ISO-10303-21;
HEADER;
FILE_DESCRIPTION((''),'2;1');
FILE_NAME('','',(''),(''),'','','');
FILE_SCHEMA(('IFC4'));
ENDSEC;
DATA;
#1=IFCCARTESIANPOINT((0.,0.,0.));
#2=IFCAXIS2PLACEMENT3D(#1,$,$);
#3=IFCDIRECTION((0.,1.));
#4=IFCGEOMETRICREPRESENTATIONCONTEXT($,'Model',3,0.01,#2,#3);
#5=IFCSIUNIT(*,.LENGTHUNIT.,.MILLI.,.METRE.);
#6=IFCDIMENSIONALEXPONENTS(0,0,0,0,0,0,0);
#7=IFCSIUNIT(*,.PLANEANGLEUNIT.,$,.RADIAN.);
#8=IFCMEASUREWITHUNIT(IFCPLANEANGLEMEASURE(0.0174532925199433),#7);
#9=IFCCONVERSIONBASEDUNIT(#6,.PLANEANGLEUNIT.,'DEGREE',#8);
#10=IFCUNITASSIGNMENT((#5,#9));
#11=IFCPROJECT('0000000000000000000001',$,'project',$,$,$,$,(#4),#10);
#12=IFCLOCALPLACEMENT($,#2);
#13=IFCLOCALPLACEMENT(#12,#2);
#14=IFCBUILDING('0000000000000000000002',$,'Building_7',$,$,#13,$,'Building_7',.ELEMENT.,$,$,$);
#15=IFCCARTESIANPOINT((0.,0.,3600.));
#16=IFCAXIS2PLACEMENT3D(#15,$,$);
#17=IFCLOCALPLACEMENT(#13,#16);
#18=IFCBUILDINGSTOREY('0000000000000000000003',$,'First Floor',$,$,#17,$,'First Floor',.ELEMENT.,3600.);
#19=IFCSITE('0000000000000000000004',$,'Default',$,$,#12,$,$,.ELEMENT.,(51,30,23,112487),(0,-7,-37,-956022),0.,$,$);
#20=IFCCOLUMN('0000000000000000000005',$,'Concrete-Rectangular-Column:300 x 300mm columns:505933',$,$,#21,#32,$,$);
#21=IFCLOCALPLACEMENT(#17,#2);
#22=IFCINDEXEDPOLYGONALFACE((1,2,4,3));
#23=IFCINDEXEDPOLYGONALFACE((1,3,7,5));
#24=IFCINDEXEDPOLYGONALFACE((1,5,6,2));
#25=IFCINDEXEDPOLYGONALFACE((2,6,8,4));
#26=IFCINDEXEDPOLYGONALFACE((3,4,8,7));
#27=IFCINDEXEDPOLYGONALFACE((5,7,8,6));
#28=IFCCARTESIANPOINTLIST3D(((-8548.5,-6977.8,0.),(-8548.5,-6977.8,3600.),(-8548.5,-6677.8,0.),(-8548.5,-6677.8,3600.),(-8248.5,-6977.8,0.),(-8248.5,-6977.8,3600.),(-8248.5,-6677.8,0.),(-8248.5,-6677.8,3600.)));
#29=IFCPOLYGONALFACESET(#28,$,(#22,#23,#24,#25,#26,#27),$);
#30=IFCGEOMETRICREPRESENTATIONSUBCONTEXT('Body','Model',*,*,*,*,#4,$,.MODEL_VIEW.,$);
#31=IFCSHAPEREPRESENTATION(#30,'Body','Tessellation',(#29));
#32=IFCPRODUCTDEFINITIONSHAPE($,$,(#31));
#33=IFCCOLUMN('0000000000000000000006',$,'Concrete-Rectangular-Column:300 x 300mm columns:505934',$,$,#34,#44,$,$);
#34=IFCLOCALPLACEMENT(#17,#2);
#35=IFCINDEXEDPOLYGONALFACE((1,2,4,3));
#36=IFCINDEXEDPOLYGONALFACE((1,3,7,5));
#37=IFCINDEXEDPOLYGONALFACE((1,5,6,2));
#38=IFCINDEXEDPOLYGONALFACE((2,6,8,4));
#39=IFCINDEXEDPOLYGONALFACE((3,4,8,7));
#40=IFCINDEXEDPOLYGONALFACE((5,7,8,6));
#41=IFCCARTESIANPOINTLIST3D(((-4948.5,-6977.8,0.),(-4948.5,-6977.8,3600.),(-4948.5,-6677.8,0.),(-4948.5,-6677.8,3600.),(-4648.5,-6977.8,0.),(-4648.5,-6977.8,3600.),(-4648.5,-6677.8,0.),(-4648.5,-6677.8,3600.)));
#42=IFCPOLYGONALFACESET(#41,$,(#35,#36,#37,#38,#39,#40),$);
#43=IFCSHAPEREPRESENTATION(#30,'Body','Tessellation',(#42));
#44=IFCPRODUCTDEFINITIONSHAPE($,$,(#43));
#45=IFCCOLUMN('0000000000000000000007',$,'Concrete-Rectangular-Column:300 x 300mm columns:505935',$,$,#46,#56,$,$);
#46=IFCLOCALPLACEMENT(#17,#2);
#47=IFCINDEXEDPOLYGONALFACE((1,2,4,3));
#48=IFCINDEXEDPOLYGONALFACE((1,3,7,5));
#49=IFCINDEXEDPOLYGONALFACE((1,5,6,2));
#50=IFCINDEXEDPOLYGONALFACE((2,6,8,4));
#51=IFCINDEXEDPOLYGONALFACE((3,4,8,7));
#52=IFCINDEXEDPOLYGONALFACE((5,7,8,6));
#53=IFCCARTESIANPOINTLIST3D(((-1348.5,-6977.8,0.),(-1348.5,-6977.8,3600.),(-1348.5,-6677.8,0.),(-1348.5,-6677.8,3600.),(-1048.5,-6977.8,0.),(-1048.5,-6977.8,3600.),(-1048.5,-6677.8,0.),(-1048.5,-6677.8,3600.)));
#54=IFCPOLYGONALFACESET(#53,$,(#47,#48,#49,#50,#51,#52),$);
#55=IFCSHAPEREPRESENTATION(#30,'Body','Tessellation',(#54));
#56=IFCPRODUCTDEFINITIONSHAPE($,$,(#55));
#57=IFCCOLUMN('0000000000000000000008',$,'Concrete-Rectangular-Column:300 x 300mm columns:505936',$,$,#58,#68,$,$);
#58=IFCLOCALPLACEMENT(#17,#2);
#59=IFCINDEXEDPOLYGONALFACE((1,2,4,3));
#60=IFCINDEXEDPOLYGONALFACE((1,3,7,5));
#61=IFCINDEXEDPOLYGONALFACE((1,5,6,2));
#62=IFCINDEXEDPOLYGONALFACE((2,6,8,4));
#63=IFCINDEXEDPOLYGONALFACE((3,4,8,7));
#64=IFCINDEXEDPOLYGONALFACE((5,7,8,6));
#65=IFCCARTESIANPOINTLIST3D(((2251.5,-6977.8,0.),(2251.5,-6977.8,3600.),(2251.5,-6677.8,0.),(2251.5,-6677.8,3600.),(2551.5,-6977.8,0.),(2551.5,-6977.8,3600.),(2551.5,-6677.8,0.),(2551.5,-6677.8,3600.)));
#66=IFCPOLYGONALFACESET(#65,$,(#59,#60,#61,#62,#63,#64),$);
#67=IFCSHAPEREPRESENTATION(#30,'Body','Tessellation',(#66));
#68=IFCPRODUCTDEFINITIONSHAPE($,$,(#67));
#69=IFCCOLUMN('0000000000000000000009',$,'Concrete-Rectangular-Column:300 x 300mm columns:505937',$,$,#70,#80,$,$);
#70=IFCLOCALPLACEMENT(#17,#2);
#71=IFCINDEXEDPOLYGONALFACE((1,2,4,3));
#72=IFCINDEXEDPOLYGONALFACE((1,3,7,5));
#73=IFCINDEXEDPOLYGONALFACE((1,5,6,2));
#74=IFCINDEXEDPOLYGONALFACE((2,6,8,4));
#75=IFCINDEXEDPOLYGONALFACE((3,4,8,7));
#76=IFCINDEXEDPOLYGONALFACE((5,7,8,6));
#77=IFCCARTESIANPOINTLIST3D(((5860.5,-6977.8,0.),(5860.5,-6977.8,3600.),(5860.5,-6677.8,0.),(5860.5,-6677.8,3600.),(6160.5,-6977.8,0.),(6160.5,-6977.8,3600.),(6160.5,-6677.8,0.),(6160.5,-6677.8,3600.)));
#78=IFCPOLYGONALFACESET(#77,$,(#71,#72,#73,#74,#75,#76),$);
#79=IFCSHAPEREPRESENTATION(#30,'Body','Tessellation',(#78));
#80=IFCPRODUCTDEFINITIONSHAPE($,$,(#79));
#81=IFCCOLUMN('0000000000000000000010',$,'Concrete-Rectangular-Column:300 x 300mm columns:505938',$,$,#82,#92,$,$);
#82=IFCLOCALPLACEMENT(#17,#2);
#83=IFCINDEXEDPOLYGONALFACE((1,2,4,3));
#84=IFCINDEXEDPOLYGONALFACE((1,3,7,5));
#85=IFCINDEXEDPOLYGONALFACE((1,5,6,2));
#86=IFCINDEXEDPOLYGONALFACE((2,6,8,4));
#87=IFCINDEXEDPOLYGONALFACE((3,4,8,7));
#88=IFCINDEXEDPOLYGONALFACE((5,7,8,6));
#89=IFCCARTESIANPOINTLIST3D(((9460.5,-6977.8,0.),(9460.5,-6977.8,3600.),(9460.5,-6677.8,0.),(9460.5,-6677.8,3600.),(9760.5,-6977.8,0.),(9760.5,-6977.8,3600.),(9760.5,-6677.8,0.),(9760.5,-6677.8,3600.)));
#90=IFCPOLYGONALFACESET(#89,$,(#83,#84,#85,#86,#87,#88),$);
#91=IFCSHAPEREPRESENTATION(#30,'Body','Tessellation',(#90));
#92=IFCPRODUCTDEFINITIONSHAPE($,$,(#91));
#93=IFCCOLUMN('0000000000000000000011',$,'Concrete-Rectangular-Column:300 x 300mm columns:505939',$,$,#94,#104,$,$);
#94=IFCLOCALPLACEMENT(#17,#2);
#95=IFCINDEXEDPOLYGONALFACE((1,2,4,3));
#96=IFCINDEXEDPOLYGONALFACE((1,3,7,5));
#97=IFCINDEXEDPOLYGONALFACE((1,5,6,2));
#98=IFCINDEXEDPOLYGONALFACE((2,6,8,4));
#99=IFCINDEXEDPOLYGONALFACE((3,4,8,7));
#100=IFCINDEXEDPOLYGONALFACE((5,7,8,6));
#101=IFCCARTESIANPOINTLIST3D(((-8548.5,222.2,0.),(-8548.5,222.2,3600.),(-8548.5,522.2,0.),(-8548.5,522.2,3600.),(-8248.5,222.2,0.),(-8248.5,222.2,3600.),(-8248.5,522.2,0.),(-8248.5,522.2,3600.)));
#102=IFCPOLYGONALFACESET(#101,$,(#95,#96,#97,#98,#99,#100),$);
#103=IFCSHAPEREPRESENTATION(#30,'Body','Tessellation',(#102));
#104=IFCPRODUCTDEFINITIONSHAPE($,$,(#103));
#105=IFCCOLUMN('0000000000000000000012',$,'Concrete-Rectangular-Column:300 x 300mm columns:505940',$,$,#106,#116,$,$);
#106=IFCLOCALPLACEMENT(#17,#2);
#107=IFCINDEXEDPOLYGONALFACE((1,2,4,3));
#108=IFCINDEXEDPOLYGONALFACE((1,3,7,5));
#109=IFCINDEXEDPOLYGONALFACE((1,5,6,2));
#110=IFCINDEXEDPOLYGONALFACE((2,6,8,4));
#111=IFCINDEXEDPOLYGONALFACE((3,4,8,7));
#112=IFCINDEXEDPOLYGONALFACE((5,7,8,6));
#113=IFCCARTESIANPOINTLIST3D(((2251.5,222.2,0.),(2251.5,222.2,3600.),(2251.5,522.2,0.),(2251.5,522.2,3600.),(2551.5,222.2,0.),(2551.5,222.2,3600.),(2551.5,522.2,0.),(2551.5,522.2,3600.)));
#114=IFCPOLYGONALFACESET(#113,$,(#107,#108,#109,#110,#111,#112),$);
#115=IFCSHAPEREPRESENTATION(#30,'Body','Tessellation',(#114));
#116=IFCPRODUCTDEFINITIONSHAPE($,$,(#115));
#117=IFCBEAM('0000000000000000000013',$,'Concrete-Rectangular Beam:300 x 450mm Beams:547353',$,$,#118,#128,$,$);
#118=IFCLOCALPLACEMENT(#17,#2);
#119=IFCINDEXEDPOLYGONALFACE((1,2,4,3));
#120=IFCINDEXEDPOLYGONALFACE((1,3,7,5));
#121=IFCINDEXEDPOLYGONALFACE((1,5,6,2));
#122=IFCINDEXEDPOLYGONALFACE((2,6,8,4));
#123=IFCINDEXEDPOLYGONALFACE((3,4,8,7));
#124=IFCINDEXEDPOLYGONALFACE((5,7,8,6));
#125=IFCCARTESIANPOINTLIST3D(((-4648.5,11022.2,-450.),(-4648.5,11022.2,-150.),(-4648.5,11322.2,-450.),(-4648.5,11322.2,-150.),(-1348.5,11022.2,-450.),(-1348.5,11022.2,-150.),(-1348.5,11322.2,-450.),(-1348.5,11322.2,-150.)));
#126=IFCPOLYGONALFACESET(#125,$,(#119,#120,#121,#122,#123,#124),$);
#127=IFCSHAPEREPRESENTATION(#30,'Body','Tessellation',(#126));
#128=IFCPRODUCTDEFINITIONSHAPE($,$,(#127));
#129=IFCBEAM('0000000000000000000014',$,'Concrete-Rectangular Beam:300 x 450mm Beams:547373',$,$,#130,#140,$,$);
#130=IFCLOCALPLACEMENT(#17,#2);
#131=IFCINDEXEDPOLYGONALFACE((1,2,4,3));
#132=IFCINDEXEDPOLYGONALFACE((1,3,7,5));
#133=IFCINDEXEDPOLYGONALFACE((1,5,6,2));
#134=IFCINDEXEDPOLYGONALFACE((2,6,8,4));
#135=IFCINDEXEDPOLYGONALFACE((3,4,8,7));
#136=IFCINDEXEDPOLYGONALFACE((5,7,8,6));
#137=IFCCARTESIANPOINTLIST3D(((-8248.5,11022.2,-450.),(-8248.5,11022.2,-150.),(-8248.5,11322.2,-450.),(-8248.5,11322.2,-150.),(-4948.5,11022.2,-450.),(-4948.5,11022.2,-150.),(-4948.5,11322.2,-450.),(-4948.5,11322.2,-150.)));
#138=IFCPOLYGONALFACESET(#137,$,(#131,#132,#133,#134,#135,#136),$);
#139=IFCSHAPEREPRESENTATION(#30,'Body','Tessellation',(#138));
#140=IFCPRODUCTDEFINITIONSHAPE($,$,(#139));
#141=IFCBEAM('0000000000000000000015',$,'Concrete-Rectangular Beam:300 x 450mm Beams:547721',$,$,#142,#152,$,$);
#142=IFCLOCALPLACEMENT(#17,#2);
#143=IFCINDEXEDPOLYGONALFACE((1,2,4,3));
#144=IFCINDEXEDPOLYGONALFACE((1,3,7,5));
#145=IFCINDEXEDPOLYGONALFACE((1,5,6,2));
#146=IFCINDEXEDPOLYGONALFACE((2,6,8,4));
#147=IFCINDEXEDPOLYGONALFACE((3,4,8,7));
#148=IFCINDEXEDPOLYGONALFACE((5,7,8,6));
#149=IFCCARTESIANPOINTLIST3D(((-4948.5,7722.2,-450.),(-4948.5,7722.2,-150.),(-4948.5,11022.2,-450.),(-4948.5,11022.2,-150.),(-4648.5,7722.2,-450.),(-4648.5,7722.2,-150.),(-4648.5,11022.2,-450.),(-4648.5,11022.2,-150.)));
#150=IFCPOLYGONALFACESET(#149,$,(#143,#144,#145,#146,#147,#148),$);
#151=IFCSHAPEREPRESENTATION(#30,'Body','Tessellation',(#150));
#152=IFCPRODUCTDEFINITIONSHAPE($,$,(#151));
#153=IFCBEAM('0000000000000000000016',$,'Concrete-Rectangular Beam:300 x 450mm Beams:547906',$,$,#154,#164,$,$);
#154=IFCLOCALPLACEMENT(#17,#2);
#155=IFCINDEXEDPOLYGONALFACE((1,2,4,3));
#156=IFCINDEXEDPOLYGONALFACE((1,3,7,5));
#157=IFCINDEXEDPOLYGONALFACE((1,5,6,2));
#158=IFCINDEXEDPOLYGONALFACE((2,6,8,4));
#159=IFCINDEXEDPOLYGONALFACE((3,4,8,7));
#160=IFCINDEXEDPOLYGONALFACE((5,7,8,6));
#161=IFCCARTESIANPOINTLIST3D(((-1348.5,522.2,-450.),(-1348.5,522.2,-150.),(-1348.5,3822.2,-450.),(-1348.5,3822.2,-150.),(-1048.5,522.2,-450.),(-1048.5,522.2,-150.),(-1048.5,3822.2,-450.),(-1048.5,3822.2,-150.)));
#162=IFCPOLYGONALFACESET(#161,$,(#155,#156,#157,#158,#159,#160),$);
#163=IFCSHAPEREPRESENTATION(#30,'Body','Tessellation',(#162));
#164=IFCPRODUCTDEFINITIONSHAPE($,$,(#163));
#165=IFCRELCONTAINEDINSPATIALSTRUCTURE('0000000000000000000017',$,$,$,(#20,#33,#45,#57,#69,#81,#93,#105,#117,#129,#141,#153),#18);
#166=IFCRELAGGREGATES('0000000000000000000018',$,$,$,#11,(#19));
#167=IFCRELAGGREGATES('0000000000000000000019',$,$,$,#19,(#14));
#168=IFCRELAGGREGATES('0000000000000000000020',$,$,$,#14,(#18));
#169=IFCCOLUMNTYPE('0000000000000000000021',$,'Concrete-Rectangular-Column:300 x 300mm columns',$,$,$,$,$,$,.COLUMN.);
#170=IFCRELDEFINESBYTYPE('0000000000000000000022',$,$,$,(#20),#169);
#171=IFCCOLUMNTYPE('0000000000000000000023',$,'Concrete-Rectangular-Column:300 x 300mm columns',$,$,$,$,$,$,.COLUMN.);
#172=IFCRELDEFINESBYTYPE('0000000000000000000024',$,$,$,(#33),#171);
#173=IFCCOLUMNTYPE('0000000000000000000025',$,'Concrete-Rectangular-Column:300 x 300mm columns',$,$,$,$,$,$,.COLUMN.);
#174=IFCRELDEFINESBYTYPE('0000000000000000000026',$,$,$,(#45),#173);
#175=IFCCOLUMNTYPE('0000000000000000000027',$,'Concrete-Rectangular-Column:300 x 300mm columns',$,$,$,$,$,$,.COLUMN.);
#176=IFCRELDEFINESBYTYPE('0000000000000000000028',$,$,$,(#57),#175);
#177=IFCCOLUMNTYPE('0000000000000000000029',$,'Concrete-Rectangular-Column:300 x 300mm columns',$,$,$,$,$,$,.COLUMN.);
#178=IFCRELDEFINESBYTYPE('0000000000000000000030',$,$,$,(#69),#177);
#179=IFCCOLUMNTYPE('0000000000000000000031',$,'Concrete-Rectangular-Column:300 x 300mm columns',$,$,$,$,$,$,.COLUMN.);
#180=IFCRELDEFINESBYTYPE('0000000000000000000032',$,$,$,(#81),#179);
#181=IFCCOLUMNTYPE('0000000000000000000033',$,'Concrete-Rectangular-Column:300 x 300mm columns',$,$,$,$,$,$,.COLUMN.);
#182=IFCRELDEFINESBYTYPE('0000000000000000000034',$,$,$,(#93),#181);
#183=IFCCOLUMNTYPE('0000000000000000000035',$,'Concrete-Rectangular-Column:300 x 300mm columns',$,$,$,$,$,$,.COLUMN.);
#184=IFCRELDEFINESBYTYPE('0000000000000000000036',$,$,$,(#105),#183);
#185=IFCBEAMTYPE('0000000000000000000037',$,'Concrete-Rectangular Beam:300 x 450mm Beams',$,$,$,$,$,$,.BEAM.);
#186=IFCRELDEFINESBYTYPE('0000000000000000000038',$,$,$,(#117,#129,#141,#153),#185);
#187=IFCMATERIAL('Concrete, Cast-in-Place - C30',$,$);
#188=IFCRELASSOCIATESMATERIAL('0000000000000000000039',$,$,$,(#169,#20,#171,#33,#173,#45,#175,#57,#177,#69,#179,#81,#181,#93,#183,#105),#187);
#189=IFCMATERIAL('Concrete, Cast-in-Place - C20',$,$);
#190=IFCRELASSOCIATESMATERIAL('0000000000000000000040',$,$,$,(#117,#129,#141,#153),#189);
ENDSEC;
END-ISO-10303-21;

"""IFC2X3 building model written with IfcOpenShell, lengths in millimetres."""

from ifc_helpers import new_model, entity, si_unit, converted_unit, direction, frame, frame_2d, origin, place, context, subcontext, project, spatial, rectangle, extrude, source, transform, mapped, material, type_object, type_shapes, element, save


model = new_model("IFC2X3")

# Units and contexts
model_context = context("Model", 3, precision=0.01, world=origin(), true_north=direction((0.0, 1.0)))
body_context = subcontext(model_context, "Body", "Model", "MODEL_VIEW")
ifc_project = project(units=[si_unit("LENGTHUNIT", "METRE", prefix="MILLI"), converted_unit("PLANEANGLEUNIT", "DEGREE", entity("IfcPlaneAngleMeasure", 0.0174532925199433), si_unit("PLANEANGLEUNIT", "RADIAN"), dimensions=[0, 0, 0, 0, 0, 0, 0])], contexts=[model_context])

# Site, building, storey
site_placement = place(None, origin())
site = spatial("IfcSite", under=ifc_project, at=site_placement, Name="Default", CompositionType="ELEMENT", RefLatitude=(51, 30, 23, 112487), RefLongitude=(0, -7, -37, -956022), RefElevation=0.0)
building_placement = place(site_placement, origin())
building = spatial("IfcBuilding", under=site, at=building_placement, Name="Building_7", LongName="Building_7", CompositionType="ELEMENT")
storey_placement = place(building_placement, frame((0.0, 0.0, 3600.0)))
storey = spatial("IfcBuildingStorey", under=building, at=storey_placement, Name="First Floor", LongName="First Floor", CompositionType="ELEMENT", Elevation=3600.0)

# Columns
ifc_material_1 = material(Name="Concrete, Cast-in-Place - C30")
column_type_1 = type_object("IfcColumnType", Name="Concrete-Rectangular-Column:300 x 300mm columns", PredefinedType="COLUMN", material=ifc_material_1)
shared_shape_1 = source(origin(), body_context, "Body", "SweptSolid", [
    extrude(rectangle(XDim=300.0, YDim=300.0, at=frame_2d((0.0, 0.0), x_axis=(1.0, 0.0))), frame((-8398.5, -6827.8, 3600.0), z_axis=(0.0, 0.0, 1.0), x_axis=(-1.0, 0.0, 0.0)), (0.0, 0.0, 1.0), 3600.0),
])
type_shapes(column_type_1, [shared_shape_1])
column_1_placement = place(storey_placement, frame((0.0, 0.0, -3600.0)))
element("IfcColumn", 1, at=column_1_placement, inside=storey, type_object=column_type_1, material=ifc_material_1, Name="Concrete-Rectangular-Column:300 x 300mm columns:505933", context=body_context, shape_type="MappedRepresentation", body=[
    mapped(shared_shape_1, transform((0.0, 0.0, 0.0), scale=1.0)),
])
column_type_2 = type_object("IfcColumnType", Name="Concrete-Rectangular-Column:300 x 300mm columns", PredefinedType="COLUMN", material=ifc_material_1)
shared_shape_2 = source(origin(), body_context, "Body", "SweptSolid", [
    extrude(rectangle(XDim=300.0, YDim=300.0, at=frame_2d((0.0, 0.0), x_axis=(1.0, 0.0))), frame((-4798.5, -6827.8, 3600.0), z_axis=(0.0, 0.0, 1.0), x_axis=(-1.0, 0.0, 0.0)), (0.0, 0.0, 1.0), 3600.0),
])
type_shapes(column_type_2, [shared_shape_2])
column_2_placement = place(storey_placement, frame((0.0, 0.0, -3600.0)))
element("IfcColumn", 2, at=column_2_placement, inside=storey, type_object=column_type_2, material=ifc_material_1, Name="Concrete-Rectangular-Column:300 x 300mm columns:505934", context=body_context, shape_type="MappedRepresentation", body=[
    mapped(shared_shape_2, transform((0.0, 0.0, 0.0), scale=1.0)),
])
column_type_3 = type_object("IfcColumnType", Name="Concrete-Rectangular-Column:300 x 300mm columns", PredefinedType="COLUMN", material=ifc_material_1)
shared_shape_3 = source(origin(), body_context, "Body", "SweptSolid", [
    extrude(rectangle(XDim=300.0, YDim=300.0, at=frame_2d((0.0, 0.0), x_axis=(1.0, 0.0))), frame((-1198.5, -6827.8, 3600.0), z_axis=(0.0, 0.0, 1.0), x_axis=(-1.0, 0.0, 0.0)), (0.0, 0.0, 1.0), 3600.0),
])
type_shapes(column_type_3, [shared_shape_3])
column_3_placement = place(storey_placement, frame((0.0, 0.0, -3600.0)))
element("IfcColumn", 3, at=column_3_placement, inside=storey, type_object=column_type_3, material=ifc_material_1, Name="Concrete-Rectangular-Column:300 x 300mm columns:505935", context=body_context, shape_type="MappedRepresentation", body=[
    mapped(shared_shape_3, transform((0.0, 0.0, 0.0), scale=1.0)),
])
column_type_4 = type_object("IfcColumnType", Name="Concrete-Rectangular-Column:300 x 300mm columns", PredefinedType="COLUMN", material=ifc_material_1)
shared_shape_4 = source(origin(), body_context, "Body", "SweptSolid", [
    extrude(rectangle(XDim=300.0, YDim=300.0, at=frame_2d((0.0, 0.0), x_axis=(1.0, 0.0))), frame((2401.5, -6827.8, 3600.0), z_axis=(0.0, 0.0, 1.0), x_axis=(-1.0, 0.0, 0.0)), (0.0, 0.0, 1.0), 3600.0),
])
type_shapes(column_type_4, [shared_shape_4])
column_4_placement = place(storey_placement, frame((0.0, 0.0, -3600.0)))
element("IfcColumn", 4, at=column_4_placement, inside=storey, type_object=column_type_4, material=ifc_material_1, Name="Concrete-Rectangular-Column:300 x 300mm columns:505936", context=body_context, shape_type="MappedRepresentation", body=[
    mapped(shared_shape_4, transform((0.0, 0.0, 0.0), scale=1.0)),
])
column_type_5 = type_object("IfcColumnType", Name="Concrete-Rectangular-Column:300 x 300mm columns", PredefinedType="COLUMN", material=ifc_material_1)
shared_shape_5 = source(origin(), body_context, "Body", "SweptSolid", [
    extrude(rectangle(XDim=300.0, YDim=300.0, at=frame_2d((0.0, 0.0), x_axis=(1.0, 0.0))), frame((6010.5, -6827.8, 3600.0), z_axis=(0.0, 0.0, 1.0), x_axis=(-1.0, 0.0, 0.0)), (0.0, 0.0, 1.0), 3600.0),
])
type_shapes(column_type_5, [shared_shape_5])
column_5_placement = place(storey_placement, frame((0.0, 0.0, -3600.0)))
element("IfcColumn", 5, at=column_5_placement, inside=storey, type_object=column_type_5, material=ifc_material_1, Name="Concrete-Rectangular-Column:300 x 300mm columns:505937", context=body_context, shape_type="MappedRepresentation", body=[
    mapped(shared_shape_5, transform((0.0, 0.0, 0.0), scale=1.0)),
])
column_type_6 = type_object("IfcColumnType", Name="Concrete-Rectangular-Column:300 x 300mm columns", PredefinedType="COLUMN", material=ifc_material_1)
shared_shape_6 = source(origin(), body_context, "Body", "SweptSolid", [
    extrude(rectangle(XDim=300.0, YDim=300.0, at=frame_2d((0.0, 0.0), x_axis=(1.0, 0.0))), frame((9610.5, -6827.8, 3600.0), z_axis=(0.0, 0.0, 1.0), x_axis=(-1.0, 0.0, 0.0)), (0.0, 0.0, 1.0), 3600.0),
])
type_shapes(column_type_6, [shared_shape_6])
column_6_placement = place(storey_placement, frame((0.0, 0.0, -3600.0)))
element("IfcColumn", 6, at=column_6_placement, inside=storey, type_object=column_type_6, material=ifc_material_1, Name="Concrete-Rectangular-Column:300 x 300mm columns:505938", context=body_context, shape_type="MappedRepresentation", body=[
    mapped(shared_shape_6, transform((0.0, 0.0, 0.0), scale=1.0)),
])
column_type_7 = type_object("IfcColumnType", Name="Concrete-Rectangular-Column:300 x 300mm columns", PredefinedType="COLUMN", material=ifc_material_1)
shared_shape_7 = source(origin(), body_context, "Body", "SweptSolid", [
    extrude(rectangle(XDim=300.0, YDim=300.0, at=frame_2d((0.0, 0.0), x_axis=(1.0, 0.0))), frame((-8398.5, 372.2, 3600.0), z_axis=(0.0, 0.0, 1.0), x_axis=(-1.0, 0.0, 0.0)), (0.0, 0.0, 1.0), 3600.0),
])
type_shapes(column_type_7, [shared_shape_7])
column_7_placement = place(storey_placement, frame((0.0, 0.0, -3600.0)))
element("IfcColumn", 7, at=column_7_placement, inside=storey, type_object=column_type_7, material=ifc_material_1, Name="Concrete-Rectangular-Column:300 x 300mm columns:505939", context=body_context, shape_type="MappedRepresentation", body=[
    mapped(shared_shape_7, transform((0.0, 0.0, 0.0), scale=1.0)),
])
column_type_8 = type_object("IfcColumnType", Name="Concrete-Rectangular-Column:300 x 300mm columns", PredefinedType="COLUMN", material=ifc_material_1)
shared_shape_8 = source(origin(), body_context, "Body", "SweptSolid", [
    extrude(rectangle(XDim=300.0, YDim=300.0, at=frame_2d((0.0, 0.0), x_axis=(1.0, 0.0))), frame((2401.5, 372.2, 3600.0), z_axis=(0.0, 0.0, 1.0), x_axis=(-1.0, 0.0, 0.0)), (0.0, 0.0, 1.0), 3600.0),
])
type_shapes(column_type_8, [shared_shape_8])
column_8_placement = place(storey_placement, frame((0.0, 0.0, -3600.0)))
element("IfcColumn", 8, at=column_8_placement, inside=storey, type_object=column_type_8, material=ifc_material_1, Name="Concrete-Rectangular-Column:300 x 300mm columns:505940", context=body_context, shape_type="MappedRepresentation", body=[
    mapped(shared_shape_8, transform((0.0, 0.0, 0.0), scale=1.0)),
])

# Beams
ifc_material_2 = material(Name="Concrete, Cast-in-Place - C20")
beam_type = type_object("IfcBeamType", Name="Concrete-Rectangular Beam:300 x 450mm Beams", PredefinedType="BEAM")
for number, where, z_axis, x_axis, name in (
    (9, (-1198.5, 11172.2, 0.0), (0.0, 0.0, 1.0), (-1.0, 0.0, 0.0), "Concrete-Rectangular Beam:300 x 450mm Beams:547353"),
    (10, (-4798.5, 11172.2, 0.0), (0.0, 0.0, 1.0), (-1.0, 0.0, 0.0), "Concrete-Rectangular Beam:300 x 450mm Beams:547373"),
):
    element("IfcBeam", number, at=place(storey_placement, frame(where, z_axis=z_axis, x_axis=x_axis)), inside=storey, type_object=beam_type, material=ifc_material_2, Name=name, context=body_context, shape_type="SweptSolid", body=[
        extrude(rectangle(XDim=300.0, YDim=300.0, at=frame_2d((0.0, 0.0), x_axis=(1.0, 0.0))), frame((150.0, 0.0, -300.0), z_axis=(1.0, 0.0, 0.0), x_axis=(0.0, 0.0, -1.0)), (0.0, 0.0, 1.0), 3300.0),
    ])
beam_1_placement = place(storey_placement, frame((-4798.5, 11172.2, 0.0), z_axis=(0.0, 0.0, 1.0), x_axis=(0.0, -1.0, 0.0)))
element("IfcBeam", 11, at=beam_1_placement, inside=storey, type_object=beam_type, material=ifc_material_2, Name="Concrete-Rectangular Beam:300 x 450mm Beams:547721", context=body_context, shape_type="SweptSolid", body=[
    extrude(rectangle(XDim=300.0, YDim=300.0, at=frame_2d((0.0, 0.0), x_axis=(1.0, 0.0))), frame((150.0, 0.0, -300.0), z_axis=(1.0, 0.0, 0.0), x_axis=(0.0, 0.0, -1.0)), (0.0, 0.0, 1.0), 3300.0),
])
beam_2_placement = place(storey_placement, frame((-1198.5, 372.2, 0.0), z_axis=(0.0, 0.0, 1.0), x_axis=(0.0, 1.0, 0.0)))
element("IfcBeam", 12, at=beam_2_placement, inside=storey, type_object=beam_type, material=ifc_material_2, Name="Concrete-Rectangular Beam:300 x 450mm Beams:547906", context=body_context, shape_type="SweptSolid", body=[
    extrude(rectangle(XDim=300.0, YDim=300.0, at=frame_2d((0.0, 0.0), x_axis=(1.0, 0.0))), frame((150.0, 0.0, -300.0), z_axis=(1.0, 0.0, 0.0), x_axis=(0.0, 0.0, -1.0)), (0.0, 0.0, 1.0), 3300.0),
])

save(model, "model.ifc")
